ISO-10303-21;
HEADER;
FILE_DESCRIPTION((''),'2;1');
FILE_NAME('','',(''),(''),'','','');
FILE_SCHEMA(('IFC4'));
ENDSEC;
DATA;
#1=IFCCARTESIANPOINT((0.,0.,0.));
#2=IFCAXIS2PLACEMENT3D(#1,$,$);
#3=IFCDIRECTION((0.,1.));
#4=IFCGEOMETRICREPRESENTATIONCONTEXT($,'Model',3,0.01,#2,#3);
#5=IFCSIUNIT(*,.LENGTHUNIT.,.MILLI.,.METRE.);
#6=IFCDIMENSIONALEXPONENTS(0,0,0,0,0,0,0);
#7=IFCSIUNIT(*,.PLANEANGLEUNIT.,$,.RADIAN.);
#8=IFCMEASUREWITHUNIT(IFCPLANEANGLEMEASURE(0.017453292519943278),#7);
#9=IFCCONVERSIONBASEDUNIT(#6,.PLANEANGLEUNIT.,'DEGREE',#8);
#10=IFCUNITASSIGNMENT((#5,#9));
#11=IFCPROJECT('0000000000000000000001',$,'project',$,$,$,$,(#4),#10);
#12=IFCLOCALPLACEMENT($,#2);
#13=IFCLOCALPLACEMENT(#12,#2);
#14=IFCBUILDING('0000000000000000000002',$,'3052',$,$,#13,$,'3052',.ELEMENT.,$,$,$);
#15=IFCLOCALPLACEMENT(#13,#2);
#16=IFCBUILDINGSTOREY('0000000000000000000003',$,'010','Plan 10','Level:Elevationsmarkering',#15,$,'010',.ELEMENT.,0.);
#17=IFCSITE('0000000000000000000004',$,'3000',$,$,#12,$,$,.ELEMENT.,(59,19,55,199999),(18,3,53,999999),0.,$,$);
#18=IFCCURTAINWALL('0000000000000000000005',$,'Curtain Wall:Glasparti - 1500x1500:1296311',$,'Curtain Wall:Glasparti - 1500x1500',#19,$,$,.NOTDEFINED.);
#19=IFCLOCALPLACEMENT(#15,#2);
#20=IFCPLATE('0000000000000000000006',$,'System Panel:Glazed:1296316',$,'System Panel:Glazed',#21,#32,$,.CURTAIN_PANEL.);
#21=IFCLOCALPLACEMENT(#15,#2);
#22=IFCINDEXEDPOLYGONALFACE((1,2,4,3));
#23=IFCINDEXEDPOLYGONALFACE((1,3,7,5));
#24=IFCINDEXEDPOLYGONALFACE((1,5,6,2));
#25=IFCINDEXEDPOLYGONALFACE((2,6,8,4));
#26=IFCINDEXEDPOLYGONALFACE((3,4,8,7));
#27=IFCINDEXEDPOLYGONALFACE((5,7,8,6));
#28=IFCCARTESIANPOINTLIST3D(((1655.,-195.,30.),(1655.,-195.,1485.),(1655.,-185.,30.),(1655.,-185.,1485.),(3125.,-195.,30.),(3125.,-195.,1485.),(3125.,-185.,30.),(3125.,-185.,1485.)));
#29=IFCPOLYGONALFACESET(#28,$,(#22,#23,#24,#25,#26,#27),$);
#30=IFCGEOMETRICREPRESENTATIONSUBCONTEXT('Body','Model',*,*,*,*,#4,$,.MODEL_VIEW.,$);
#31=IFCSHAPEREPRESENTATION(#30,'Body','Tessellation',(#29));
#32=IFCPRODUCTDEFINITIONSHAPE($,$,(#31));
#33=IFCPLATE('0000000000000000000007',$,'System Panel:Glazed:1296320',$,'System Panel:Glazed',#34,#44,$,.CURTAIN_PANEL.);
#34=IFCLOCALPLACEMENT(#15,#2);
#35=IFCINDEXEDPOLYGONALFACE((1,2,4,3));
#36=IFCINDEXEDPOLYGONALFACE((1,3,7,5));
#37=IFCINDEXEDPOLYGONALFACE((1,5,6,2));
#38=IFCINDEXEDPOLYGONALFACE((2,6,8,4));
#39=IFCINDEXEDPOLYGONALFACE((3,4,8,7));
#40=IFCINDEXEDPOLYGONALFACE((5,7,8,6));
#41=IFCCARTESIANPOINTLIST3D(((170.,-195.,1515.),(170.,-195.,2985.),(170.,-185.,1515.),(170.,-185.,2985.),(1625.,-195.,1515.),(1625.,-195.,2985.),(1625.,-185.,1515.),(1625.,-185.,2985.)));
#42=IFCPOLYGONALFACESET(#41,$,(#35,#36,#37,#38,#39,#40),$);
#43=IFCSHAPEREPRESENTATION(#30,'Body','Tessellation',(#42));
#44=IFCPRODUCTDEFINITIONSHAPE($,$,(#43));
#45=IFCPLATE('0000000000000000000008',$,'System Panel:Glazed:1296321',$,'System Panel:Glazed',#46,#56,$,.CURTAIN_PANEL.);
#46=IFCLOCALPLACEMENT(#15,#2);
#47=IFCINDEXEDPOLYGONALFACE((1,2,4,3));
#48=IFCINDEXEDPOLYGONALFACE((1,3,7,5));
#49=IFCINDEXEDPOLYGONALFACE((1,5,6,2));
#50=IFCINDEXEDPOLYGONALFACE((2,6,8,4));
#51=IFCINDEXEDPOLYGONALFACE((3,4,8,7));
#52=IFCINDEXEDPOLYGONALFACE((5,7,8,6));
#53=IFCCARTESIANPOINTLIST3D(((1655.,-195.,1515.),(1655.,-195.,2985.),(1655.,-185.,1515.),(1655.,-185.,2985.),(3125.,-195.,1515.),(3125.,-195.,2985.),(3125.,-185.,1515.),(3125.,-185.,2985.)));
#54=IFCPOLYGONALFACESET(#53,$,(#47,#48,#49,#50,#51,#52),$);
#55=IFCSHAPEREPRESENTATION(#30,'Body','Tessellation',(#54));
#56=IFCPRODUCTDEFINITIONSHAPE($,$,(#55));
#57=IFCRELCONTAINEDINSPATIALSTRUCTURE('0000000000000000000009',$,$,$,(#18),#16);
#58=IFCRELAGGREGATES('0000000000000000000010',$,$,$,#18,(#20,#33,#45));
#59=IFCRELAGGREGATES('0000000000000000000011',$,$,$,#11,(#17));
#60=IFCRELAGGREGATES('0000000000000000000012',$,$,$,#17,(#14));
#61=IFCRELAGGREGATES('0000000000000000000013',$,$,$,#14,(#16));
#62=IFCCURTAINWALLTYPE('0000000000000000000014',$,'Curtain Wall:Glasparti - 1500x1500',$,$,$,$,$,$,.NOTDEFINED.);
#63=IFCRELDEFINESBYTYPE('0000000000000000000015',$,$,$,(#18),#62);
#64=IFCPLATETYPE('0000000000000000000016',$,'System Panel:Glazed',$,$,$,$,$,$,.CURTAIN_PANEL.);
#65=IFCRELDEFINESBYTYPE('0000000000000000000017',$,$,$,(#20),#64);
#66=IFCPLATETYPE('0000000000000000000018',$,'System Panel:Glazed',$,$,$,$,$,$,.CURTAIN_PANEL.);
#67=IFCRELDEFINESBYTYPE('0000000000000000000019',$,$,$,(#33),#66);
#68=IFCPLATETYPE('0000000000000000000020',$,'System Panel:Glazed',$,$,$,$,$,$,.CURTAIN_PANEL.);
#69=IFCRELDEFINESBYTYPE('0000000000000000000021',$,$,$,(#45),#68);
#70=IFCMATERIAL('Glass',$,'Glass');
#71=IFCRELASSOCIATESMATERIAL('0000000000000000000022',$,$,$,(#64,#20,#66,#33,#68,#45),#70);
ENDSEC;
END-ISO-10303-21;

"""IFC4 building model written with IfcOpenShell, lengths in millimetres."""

from ifc_helpers import new_model, entity, si_unit, converted_unit, direction, frame, origin, place, context, subcontext, project, spatial, indexed_curve, outline, extrude, source, transform, mapped, material, type_object, type_shapes, element, aggregate, save


model = new_model("IFC4")

# Units and contexts
model_context = context("Model", 3, precision=0.01, world=origin(), true_north=direction((0.0, 1.0)))
body_context = subcontext(model_context, "Body", "Model", "MODEL_VIEW")
ifc_project = project(units=[si_unit("LENGTHUNIT", "METRE", prefix="MILLI"), converted_unit("PLANEANGLEUNIT", "DEGREE", entity("IfcPlaneAngleMeasure", 0.017453292519943278), si_unit("PLANEANGLEUNIT", "RADIAN"), dimensions=[0, 0, 0, 0, 0, 0, 0])], contexts=[model_context])

# Site, building, storey
site_placement = place(None, origin())
site = spatial("IfcSite", under=ifc_project, at=site_placement, Name="3000", CompositionType="ELEMENT", RefLatitude=(59, 19, 55, 199999), RefLongitude=(18, 3, 53, 999999), RefElevation=0.0)
building_placement = place(site_placement, origin())
building = spatial("IfcBuilding", under=site, at=building_placement, Name="3052", LongName="3052", CompositionType="ELEMENT")
storey_placement = place(building_placement, origin())
storey = spatial("IfcBuildingStorey", under=building, at=storey_placement, Name="010", Description="Plan 10", ObjectType="Level:Elevationsmarkering", LongName="010", CompositionType="ELEMENT", Elevation=0.0)

# Curtain wall
curtain_wall_type = type_object("IfcCurtainWallType", Name="Curtain Wall:Glasparti - 1500x1500", PredefinedType="NOTDEFINED")
curtain_wall_placement = place(storey_placement, origin())
curtain_wall = element("IfcCurtainWall", 1, at=curtain_wall_placement, inside=storey, type_object=curtain_wall_type, Name="Curtain Wall:Glasparti - 1500x1500:1296311", ObjectType="Curtain Wall:Glasparti - 1500x1500", PredefinedType="NOTDEFINED")

# Plates
ifc_material_1 = material(Name="Glass", Category="Glass")
plate_type_1 = type_object("IfcPlateType", Name="System Panel:Glazed", PredefinedType="CURTAIN_PANEL", material=ifc_material_1)
shared_shape_1 = source(origin(), body_context, "Body", "SweptSolid", [
    extrude(outline(indexed_curve([(-5.0, -735.0), (5.0, -735.0), (5.0, 735.0), (-5.0, 735.0), (-5.0, -735.0)], self_intersect=False)), frame((0.0, 0.0, 0.0), z_axis=(0.0, 0.0, 1.0), x_axis=(0.0, 1.0, 0.0)), (0.0, 0.0, 1.0), 1455.0),
])
type_shapes(plate_type_1, [shared_shape_1])
plate_1_placement = place(curtain_wall_placement, frame((2390.0, -190.0, 30.0)))
plate_1 = element("IfcPlate", 2, at=plate_1_placement, type_object=plate_type_1, material=ifc_material_1, Name="System Panel:Glazed:1296316", ObjectType="System Panel:Glazed", PredefinedType="CURTAIN_PANEL", context=body_context, shape_type="MappedRepresentation", body=[
    mapped(shared_shape_1, transform((0.0, 0.0, 0.0), scale=1.0)),
])
plate_type_2 = type_object("IfcPlateType", Name="System Panel:Glazed", PredefinedType="CURTAIN_PANEL", material=ifc_material_1)
shared_shape_2 = source(origin(), body_context, "Body", "SweptSolid", [
    extrude(outline(indexed_curve([(-5.0, -727.5), (5.0, -727.5), (5.0, 727.5), (-5.0, 727.5), (-5.0, -727.5)], self_intersect=False)), frame((0.0, 0.0, 0.0), z_axis=(0.0, 0.0, 1.0), x_axis=(0.0, 1.0, 0.0)), (0.0, 0.0, 1.0), 1470.0),
])
type_shapes(plate_type_2, [shared_shape_2])
plate_2_placement = place(curtain_wall_placement, frame((897.5, -190.0, 1515.0)))
plate_2 = element("IfcPlate", 3, at=plate_2_placement, type_object=plate_type_2, material=ifc_material_1, Name="System Panel:Glazed:1296320", ObjectType="System Panel:Glazed", PredefinedType="CURTAIN_PANEL", context=body_context, shape_type="MappedRepresentation", body=[
    mapped(shared_shape_2, transform((0.0, 0.0, 0.0), scale=1.0)),
])
plate_type_3 = type_object("IfcPlateType", Name="System Panel:Glazed", PredefinedType="CURTAIN_PANEL", material=ifc_material_1)
shared_shape_3 = source(origin(), body_context, "Body", "SweptSolid", [
    extrude(outline(indexed_curve([(-5.0, -735.0), (5.0, -735.0), (5.0, 735.0), (-5.0, 735.0), (-5.0, -735.0)], self_intersect=False)), frame((0.0, 0.0, 0.0), z_axis=(0.0, 0.0, 1.0), x_axis=(0.0, 1.0, 0.0)), (0.0, 0.0, 1.0), 1470.0),
])
type_shapes(plate_type_3, [shared_shape_3])
plate_3_placement = place(curtain_wall_placement, frame((2390.0, -190.0, 1515.0)))
plate_3 = element("IfcPlate", 4, at=plate_3_placement, type_object=plate_type_3, material=ifc_material_1, Name="System Panel:Glazed:1296321", ObjectType="System Panel:Glazed", PredefinedType="CURTAIN_PANEL", context=body_context, shape_type="MappedRepresentation", body=[
    mapped(shared_shape_3, transform((0.0, 0.0, 0.0), scale=1.0)),
])
aggregate(curtain_wall, [plate_1, plate_2, plate_3])

save(model, "model.ifc")
